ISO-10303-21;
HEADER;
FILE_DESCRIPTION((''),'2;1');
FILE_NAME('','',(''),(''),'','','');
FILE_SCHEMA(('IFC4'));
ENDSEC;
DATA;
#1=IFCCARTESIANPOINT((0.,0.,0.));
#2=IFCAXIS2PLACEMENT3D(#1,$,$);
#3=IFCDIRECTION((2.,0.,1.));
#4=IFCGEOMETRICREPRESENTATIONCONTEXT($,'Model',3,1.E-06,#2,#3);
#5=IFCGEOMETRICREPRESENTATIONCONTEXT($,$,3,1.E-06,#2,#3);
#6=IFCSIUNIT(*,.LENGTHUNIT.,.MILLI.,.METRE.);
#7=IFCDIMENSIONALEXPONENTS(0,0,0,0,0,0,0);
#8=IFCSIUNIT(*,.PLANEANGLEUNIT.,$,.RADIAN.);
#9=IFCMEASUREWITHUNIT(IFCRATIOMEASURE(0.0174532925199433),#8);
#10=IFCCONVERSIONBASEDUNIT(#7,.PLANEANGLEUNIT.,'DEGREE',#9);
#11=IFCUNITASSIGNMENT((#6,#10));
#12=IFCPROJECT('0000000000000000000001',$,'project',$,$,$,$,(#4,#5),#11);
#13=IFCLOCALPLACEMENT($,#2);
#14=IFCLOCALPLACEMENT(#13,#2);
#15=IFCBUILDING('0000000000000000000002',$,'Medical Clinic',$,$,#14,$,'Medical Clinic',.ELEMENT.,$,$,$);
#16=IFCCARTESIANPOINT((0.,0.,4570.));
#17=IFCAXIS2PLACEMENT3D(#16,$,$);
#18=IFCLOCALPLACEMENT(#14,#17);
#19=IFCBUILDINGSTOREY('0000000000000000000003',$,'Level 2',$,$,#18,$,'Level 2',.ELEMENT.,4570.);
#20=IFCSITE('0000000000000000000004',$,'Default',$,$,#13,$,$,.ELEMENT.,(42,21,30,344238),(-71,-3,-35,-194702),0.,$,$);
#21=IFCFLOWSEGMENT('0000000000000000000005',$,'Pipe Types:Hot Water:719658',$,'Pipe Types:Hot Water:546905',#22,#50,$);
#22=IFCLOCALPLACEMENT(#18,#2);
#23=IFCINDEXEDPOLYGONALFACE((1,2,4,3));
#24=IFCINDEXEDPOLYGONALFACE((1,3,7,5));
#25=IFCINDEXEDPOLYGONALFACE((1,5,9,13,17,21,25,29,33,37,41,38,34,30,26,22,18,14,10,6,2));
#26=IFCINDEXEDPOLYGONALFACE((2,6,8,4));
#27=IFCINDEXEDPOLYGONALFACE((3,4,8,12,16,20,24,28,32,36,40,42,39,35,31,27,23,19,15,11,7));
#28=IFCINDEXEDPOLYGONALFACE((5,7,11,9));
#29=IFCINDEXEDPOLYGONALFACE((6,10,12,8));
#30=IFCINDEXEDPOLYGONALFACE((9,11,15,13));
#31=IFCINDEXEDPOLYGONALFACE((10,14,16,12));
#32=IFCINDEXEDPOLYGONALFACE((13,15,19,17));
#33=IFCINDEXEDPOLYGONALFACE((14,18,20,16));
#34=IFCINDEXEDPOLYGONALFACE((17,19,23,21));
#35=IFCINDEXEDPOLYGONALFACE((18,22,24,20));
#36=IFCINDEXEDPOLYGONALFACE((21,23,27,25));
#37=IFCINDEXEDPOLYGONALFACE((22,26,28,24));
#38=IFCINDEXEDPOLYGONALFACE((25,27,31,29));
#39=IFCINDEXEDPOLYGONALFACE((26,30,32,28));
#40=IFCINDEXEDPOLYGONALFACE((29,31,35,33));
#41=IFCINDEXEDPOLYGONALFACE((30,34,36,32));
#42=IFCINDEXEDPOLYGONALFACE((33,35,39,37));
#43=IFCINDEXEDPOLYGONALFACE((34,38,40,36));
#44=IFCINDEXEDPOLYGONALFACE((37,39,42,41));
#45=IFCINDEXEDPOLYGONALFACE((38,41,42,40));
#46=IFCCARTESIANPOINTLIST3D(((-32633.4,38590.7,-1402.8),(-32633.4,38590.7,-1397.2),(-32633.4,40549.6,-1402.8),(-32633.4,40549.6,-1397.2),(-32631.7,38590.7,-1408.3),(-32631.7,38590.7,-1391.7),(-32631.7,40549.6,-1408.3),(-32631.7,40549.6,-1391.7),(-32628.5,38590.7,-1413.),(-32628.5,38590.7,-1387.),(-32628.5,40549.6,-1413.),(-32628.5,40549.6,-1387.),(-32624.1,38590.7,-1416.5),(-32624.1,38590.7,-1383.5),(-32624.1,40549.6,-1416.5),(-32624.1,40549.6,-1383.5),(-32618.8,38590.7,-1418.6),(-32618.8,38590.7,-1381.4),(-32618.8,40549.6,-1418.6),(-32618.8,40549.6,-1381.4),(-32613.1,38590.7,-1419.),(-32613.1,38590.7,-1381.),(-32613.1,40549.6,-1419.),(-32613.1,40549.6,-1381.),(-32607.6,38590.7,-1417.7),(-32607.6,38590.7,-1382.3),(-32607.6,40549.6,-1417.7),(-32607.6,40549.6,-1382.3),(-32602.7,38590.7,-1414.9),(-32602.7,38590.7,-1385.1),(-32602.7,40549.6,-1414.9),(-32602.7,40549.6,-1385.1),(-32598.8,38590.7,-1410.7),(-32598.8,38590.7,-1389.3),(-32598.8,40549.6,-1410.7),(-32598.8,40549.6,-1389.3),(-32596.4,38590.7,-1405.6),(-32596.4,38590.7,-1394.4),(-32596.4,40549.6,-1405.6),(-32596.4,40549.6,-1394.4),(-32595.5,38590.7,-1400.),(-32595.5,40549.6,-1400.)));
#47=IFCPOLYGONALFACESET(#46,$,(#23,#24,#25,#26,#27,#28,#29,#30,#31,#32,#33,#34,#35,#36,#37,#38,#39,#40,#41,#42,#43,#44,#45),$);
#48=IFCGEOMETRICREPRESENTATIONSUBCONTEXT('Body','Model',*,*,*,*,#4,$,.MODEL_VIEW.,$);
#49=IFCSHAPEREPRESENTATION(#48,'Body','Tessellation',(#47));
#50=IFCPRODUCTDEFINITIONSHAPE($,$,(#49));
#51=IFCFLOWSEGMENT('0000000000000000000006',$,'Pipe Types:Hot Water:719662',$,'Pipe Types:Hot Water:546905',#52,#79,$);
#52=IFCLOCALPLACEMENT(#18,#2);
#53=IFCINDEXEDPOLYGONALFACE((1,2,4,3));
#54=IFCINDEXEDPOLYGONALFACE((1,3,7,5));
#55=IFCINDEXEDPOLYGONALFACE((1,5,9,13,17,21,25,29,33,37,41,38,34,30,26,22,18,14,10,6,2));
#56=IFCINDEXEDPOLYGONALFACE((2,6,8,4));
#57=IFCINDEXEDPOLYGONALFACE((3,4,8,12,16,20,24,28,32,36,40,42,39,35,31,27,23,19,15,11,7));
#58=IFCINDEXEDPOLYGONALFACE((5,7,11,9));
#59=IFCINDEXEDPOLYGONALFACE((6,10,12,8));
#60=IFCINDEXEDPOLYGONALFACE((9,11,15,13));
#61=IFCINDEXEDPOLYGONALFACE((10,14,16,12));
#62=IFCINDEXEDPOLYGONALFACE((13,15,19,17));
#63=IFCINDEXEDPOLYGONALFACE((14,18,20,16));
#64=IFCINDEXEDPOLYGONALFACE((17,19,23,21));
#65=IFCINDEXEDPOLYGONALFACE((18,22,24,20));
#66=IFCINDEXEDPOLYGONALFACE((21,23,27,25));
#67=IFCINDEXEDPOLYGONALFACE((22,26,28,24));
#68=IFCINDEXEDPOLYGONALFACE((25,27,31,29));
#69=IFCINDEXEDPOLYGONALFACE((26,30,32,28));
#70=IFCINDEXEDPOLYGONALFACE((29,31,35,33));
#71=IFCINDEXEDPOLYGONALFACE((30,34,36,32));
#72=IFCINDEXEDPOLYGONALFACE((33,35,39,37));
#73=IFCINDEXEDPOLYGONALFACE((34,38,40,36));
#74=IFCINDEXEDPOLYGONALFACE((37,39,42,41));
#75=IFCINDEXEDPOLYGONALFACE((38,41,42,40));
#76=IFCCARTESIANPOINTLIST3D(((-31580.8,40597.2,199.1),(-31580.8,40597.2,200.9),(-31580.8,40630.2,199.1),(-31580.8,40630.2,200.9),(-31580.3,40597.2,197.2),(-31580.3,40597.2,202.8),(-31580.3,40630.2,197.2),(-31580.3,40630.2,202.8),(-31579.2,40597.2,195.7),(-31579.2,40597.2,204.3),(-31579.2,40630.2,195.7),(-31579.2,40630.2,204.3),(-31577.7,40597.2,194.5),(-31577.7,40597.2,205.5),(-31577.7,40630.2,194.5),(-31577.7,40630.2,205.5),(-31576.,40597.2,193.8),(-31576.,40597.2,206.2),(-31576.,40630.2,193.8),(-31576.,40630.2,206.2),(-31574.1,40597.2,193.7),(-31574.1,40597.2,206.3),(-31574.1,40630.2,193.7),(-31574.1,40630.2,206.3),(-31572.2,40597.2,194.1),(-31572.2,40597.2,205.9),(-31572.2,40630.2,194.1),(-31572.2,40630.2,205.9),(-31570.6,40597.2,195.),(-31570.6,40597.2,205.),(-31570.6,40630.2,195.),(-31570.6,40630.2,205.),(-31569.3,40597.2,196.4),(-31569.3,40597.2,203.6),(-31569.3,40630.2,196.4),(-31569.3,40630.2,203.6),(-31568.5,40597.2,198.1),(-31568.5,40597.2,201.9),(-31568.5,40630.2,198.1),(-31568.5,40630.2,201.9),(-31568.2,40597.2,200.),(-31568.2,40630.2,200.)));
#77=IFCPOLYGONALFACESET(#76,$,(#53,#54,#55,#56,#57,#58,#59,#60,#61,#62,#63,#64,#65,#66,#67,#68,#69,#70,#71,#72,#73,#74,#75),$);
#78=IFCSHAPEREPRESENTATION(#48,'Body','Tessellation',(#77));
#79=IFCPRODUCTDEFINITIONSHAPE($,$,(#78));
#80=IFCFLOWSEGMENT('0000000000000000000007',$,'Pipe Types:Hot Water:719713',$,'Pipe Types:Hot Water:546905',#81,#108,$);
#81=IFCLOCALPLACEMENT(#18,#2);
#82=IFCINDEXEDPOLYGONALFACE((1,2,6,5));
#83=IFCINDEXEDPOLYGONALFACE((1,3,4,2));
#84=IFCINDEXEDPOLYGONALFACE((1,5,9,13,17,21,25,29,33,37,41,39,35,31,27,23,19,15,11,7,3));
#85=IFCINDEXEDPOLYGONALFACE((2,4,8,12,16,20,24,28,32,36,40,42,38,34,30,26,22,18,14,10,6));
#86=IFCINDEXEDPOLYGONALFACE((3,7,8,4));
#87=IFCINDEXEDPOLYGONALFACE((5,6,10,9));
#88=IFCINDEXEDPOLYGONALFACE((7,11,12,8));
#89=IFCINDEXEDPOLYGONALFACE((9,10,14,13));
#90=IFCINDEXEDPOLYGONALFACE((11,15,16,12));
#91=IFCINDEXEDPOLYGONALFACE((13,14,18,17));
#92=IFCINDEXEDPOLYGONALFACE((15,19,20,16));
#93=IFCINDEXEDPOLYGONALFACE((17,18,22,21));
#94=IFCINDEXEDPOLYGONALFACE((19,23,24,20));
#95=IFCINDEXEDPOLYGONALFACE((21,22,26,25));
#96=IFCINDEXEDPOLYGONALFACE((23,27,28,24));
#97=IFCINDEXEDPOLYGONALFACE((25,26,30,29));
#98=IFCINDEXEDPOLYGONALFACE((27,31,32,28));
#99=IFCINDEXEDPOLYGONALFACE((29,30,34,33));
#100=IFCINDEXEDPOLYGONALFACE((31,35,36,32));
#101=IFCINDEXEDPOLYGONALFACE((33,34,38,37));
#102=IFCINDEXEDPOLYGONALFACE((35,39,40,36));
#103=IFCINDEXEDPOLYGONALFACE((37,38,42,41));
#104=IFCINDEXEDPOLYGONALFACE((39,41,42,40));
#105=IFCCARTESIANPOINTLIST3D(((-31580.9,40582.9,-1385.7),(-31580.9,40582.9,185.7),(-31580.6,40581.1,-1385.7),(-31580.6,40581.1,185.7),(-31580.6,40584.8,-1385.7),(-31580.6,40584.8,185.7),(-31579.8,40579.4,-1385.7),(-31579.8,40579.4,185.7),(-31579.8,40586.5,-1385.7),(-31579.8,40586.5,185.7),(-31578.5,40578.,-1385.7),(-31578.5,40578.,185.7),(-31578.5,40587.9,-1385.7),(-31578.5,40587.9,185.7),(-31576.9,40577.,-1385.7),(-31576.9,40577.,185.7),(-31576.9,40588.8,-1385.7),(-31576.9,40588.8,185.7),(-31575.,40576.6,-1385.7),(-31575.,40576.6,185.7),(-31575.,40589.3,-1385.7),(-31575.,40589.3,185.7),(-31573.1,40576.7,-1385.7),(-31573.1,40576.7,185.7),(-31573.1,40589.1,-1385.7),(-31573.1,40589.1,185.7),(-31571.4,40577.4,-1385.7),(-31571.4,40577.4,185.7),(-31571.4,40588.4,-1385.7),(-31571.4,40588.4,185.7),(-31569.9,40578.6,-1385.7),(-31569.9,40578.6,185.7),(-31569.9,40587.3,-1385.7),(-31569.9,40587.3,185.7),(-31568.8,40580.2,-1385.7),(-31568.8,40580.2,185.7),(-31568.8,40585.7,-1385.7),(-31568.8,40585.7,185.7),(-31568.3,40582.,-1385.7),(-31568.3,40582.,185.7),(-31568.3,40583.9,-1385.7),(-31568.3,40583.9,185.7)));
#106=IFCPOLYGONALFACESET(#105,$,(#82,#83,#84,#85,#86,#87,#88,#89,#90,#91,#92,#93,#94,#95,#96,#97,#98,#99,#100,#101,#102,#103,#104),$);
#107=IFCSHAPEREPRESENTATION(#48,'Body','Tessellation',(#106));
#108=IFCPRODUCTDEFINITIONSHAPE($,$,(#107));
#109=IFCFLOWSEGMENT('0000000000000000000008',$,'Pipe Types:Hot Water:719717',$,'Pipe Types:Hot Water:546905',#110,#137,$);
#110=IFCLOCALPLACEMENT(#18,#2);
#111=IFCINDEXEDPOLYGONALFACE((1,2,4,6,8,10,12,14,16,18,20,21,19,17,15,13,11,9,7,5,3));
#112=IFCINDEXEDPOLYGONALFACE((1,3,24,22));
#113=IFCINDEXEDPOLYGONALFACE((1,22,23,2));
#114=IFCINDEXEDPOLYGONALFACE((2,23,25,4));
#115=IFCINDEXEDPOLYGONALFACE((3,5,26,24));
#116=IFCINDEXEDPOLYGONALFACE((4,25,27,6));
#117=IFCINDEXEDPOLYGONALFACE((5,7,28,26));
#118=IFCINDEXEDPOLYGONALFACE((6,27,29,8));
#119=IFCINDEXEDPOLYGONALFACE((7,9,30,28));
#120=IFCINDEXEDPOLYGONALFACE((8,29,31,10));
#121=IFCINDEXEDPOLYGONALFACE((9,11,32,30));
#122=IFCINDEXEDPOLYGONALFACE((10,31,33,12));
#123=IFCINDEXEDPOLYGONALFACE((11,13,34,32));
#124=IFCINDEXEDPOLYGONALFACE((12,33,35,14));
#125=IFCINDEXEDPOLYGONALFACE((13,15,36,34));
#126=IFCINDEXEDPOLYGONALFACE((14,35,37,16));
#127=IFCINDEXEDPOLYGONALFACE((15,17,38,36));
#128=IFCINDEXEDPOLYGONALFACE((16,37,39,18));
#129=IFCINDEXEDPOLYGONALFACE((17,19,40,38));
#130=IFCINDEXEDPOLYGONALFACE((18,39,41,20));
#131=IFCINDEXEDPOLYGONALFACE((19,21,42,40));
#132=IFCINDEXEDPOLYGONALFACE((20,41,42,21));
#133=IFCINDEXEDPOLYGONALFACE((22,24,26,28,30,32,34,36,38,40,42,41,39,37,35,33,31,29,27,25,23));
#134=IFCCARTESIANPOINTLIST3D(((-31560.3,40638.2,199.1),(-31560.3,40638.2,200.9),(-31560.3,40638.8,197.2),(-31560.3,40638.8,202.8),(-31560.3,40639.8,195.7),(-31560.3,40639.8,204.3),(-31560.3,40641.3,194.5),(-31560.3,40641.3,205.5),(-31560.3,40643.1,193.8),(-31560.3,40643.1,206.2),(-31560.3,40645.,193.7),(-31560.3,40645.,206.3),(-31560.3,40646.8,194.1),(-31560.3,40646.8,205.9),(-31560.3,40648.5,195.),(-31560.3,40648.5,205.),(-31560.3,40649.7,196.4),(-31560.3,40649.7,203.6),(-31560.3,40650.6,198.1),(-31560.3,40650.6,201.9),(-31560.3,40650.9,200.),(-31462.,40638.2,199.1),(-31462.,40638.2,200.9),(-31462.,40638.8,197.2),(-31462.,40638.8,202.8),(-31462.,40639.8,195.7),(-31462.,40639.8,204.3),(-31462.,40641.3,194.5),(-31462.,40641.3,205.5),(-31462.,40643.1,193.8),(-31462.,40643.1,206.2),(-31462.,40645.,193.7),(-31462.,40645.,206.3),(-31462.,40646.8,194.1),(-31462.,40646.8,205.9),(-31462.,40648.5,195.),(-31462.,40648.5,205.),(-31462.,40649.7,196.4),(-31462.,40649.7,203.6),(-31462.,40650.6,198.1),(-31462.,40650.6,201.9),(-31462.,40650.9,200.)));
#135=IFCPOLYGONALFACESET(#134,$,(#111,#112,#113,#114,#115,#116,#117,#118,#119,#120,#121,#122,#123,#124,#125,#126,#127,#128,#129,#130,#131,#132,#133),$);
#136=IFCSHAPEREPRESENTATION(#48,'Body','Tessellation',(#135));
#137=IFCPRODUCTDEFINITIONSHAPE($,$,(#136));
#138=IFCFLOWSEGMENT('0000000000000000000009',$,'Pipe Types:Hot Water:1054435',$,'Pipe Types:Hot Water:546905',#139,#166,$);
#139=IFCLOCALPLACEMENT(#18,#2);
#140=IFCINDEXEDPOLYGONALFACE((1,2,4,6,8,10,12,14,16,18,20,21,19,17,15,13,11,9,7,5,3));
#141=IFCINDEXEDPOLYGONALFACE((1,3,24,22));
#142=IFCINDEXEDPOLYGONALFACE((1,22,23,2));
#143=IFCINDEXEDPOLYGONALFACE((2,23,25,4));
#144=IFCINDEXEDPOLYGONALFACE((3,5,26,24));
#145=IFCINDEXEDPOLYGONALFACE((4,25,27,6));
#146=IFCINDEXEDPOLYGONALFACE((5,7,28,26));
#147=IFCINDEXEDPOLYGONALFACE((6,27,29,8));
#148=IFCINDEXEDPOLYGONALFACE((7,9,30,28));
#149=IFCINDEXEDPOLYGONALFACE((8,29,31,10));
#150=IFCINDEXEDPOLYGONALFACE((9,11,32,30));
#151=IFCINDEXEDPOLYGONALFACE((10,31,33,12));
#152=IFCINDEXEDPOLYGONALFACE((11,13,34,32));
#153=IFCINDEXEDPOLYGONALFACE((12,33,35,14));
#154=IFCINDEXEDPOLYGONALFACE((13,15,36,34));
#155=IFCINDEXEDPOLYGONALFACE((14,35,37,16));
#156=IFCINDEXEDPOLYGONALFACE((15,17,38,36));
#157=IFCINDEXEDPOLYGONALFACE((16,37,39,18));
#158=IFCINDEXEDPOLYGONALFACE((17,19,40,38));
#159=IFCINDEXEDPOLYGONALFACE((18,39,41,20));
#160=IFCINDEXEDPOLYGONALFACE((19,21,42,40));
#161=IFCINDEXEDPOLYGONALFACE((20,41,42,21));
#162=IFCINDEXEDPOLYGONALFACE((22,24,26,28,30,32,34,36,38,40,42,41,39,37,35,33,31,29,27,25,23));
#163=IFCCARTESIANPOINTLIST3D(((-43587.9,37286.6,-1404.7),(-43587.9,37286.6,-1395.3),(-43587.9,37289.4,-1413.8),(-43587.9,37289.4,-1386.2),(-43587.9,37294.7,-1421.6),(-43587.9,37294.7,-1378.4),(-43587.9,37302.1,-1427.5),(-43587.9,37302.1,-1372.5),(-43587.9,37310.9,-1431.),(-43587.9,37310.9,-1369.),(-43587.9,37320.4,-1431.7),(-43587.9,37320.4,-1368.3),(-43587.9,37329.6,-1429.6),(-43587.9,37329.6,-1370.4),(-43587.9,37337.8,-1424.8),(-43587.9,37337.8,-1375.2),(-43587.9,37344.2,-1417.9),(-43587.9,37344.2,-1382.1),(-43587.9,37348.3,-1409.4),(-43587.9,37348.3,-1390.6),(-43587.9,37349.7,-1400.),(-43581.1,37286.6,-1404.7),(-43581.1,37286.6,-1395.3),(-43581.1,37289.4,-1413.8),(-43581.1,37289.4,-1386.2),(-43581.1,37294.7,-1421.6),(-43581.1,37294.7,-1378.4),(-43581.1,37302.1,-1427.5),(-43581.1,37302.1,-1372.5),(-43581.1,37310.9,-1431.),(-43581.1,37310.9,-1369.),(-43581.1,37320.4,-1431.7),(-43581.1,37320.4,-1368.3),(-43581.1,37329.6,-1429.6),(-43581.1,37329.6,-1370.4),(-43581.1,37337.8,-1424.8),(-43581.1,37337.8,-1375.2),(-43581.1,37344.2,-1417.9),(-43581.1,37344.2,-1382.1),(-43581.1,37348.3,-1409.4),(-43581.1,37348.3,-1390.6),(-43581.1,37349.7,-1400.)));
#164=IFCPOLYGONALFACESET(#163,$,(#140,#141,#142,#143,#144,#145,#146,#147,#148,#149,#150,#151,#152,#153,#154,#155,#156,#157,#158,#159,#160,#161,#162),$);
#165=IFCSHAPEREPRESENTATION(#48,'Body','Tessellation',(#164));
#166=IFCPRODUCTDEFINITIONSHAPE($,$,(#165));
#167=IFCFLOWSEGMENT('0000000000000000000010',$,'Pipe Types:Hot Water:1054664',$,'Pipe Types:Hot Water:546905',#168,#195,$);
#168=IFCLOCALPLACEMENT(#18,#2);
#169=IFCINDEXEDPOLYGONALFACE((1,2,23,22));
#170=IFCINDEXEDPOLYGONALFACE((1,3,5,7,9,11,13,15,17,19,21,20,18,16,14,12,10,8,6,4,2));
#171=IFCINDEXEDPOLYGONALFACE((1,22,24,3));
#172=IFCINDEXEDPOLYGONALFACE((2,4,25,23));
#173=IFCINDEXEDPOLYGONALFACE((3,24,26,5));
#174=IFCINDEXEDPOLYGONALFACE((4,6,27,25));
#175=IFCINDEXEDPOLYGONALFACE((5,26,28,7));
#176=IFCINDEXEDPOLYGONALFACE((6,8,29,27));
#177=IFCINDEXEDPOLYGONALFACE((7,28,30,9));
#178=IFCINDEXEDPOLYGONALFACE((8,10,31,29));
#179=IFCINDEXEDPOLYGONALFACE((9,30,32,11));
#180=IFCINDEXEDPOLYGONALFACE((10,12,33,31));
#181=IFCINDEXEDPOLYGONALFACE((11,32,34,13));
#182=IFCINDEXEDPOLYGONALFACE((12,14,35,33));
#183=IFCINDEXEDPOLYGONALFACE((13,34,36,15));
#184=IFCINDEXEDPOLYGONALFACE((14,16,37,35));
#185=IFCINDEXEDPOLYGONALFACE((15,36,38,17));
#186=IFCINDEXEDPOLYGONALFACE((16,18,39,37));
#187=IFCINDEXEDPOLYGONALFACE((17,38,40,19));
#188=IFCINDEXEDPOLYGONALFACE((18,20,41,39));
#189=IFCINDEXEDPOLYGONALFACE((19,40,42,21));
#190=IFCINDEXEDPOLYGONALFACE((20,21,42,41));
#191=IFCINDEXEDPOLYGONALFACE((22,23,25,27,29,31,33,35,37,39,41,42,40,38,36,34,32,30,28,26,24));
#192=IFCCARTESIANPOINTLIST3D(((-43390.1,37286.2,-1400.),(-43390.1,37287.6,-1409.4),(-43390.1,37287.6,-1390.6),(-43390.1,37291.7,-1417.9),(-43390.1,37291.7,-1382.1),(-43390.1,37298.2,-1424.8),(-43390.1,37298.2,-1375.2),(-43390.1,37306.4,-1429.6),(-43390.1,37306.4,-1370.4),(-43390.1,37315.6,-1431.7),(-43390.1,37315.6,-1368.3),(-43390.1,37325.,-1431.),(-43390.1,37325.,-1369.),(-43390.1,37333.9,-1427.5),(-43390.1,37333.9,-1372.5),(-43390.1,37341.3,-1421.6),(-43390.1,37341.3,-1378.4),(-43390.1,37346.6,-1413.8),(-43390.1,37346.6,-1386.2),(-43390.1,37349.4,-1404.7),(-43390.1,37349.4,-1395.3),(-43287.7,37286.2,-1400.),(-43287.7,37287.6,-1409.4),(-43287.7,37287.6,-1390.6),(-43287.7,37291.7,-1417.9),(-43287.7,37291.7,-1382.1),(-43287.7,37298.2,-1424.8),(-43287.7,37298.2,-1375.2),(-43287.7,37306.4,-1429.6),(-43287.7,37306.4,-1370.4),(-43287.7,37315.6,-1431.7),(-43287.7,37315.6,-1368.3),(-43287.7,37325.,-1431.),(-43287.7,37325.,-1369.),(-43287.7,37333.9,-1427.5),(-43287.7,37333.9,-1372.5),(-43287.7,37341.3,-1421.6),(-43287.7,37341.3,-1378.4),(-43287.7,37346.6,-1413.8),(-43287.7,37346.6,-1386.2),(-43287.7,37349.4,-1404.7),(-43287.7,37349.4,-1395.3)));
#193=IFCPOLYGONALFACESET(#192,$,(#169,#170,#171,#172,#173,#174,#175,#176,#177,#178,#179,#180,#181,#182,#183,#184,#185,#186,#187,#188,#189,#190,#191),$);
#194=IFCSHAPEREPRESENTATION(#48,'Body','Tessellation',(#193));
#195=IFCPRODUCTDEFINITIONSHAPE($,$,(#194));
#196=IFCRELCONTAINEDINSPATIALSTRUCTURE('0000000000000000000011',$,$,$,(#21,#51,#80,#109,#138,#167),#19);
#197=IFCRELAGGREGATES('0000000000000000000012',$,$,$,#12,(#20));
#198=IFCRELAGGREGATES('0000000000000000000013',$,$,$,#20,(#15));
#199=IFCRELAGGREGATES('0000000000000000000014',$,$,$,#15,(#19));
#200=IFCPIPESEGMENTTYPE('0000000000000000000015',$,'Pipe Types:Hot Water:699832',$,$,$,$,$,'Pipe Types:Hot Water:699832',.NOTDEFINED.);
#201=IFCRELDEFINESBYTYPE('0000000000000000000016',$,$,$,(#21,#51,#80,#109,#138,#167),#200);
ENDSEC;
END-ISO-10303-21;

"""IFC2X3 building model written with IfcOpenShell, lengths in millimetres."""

from ifc_helpers import new_model, entity, si_unit, converted_unit, direction, frame, frame_2d, origin, origin_2d_with_axis, place, context, subcontext, project, spatial, circle, extrude, type_object, element, save


model = new_model("IFC2X3")

# Units and contexts
model_context = context("Model", 3, precision=1e-06, world=origin(), true_north=direction((2.0, 0.0, 1.0)))
context_of_model = context(None, 3, precision=1e-06, world=origin(), true_north=direction((2.0, 0.0, 1.0)))
body_context = subcontext(model_context, "Body", "Model", "MODEL_VIEW")
ifc_project = project(units=[si_unit("LENGTHUNIT", "METRE", prefix="MILLI"), converted_unit("PLANEANGLEUNIT", "DEGREE", entity("IfcRatioMeasure", 0.0174532925199433), si_unit("PLANEANGLEUNIT", "RADIAN"), dimensions=[0, 0, 0, 0, 0, 0, 0])], contexts=[model_context, context_of_model])

# Site, building, storey
site_placement = place(None, origin())
site = spatial("IfcSite", under=ifc_project, at=site_placement, Name="Default", CompositionType="ELEMENT", RefLatitude=(42, 21, 30, 344238), RefLongitude=(-71, -3, -35, -194702), RefElevation=0.0)
building_placement = place(site_placement, origin())
building = spatial("IfcBuilding", under=site, at=building_placement, Name="Medical Clinic", LongName="Medical Clinic", CompositionType="ELEMENT")
storey_placement = place(building_placement, frame((0.0, 0.0, 4570.0)))
storey = spatial("IfcBuildingStorey", under=building, at=storey_placement, Name="Level 2", LongName="Level 2", CompositionType="ELEMENT", Elevation=4570.0)

# Flow segments
pipe_segment_type_1 = type_object("IfcPipeSegmentType", Name="Pipe Types:Hot Water:699832", ElementType="Pipe Types:Hot Water:699832", PredefinedType="NOTDEFINED")
flow_segment_1_placement = place(storey_placement, origin())
element("IfcFlowSegment", 1, at=flow_segment_1_placement, inside=storey, type_object=pipe_segment_type_1, Name="Pipe Types:Hot Water:719658", ObjectType="Pipe Types:Hot Water:546905", context=body_context, shape_type="SweptSolid", body=[
    extrude(circle(Radius=19.1, at=origin_2d_with_axis()), frame((-32614.6, 38590.7, -1400.0), z_axis=(0.0, 1.0, 0.0), x_axis=(1.0, 0.0, 0.0)), (0.0, 0.0, 1.0), 1958.9),
])
flow_segment_2_placement = place(storey_placement, origin())
element("IfcFlowSegment", 2, at=flow_segment_2_placement, inside=storey, type_object=pipe_segment_type_1, Name="Pipe Types:Hot Water:719662", ObjectType="Pipe Types:Hot Water:546905", context=body_context, shape_type="SweptSolid", body=[
    extrude(circle(Radius=6.3, at=frame_2d((0.0, 0.0), x_axis=(1.0, 0.0))), frame((-31574.6, 40597.2, 200.0), z_axis=(0.0, 1.0, 0.0), x_axis=(1.0, 0.0, 0.0)), (0.0, 0.0, 1.0), 33.0),
])
flow_segment_3_placement = place(storey_placement, origin())
element("IfcFlowSegment", 3, at=flow_segment_3_placement, inside=storey, type_object=pipe_segment_type_1, Name="Pipe Types:Hot Water:719713", ObjectType="Pipe Types:Hot Water:546905", context=body_context, shape_type="SweptSolid", body=[
    extrude(circle(Radius=6.3, at=origin_2d_with_axis()), frame((-31574.6, 40582.9, -1385.7), z_axis=(0.0, 0.0, 1.0), x_axis=(-1.0, 0.0, 0.0)), (0.0, 0.0, 1.0), 1571.4),
])
flow_segment_4_placement = place(storey_placement, origin())
element("IfcFlowSegment", 4, at=flow_segment_4_placement, inside=storey, type_object=pipe_segment_type_1, Name="Pipe Types:Hot Water:719717", ObjectType="Pipe Types:Hot Water:546905", context=body_context, shape_type="SweptSolid", body=[
    extrude(circle(Radius=6.3, at=origin_2d_with_axis()), frame((-31560.3, 40644.5, 200.0), z_axis=(1.0, 0.0, 0.0), x_axis=(0.0, 1.0, 0.0)), (0.0, 0.0, 1.0), 98.3),
])
flow_segment_5_placement = place(storey_placement, origin())
element("IfcFlowSegment", 5, at=flow_segment_5_placement, inside=storey, type_object=pipe_segment_type_1, Name="Pipe Types:Hot Water:1054435", ObjectType="Pipe Types:Hot Water:546905", context=body_context, shape_type="SweptSolid", body=[
    extrude(circle(Radius=31.8, at=origin_2d_with_axis()), frame((-43587.9, 37318.0, -1400.0), z_axis=(1.0, 0.0, 0.0), x_axis=(0.0, 1.0, 0.0)), (0.0, 0.0, 1.0), 6.8),
])
flow_segment_6_placement = place(storey_placement, origin())
element("IfcFlowSegment", 6, at=flow_segment_6_placement, inside=storey, type_object=pipe_segment_type_1, Name="Pipe Types:Hot Water:1054664", ObjectType="Pipe Types:Hot Water:546905", context=body_context, shape_type="SweptSolid", body=[
    extrude(circle(Radius=31.8, at=origin_2d_with_axis()), frame((-43390.1, 37318.0, -1400.0), z_axis=(1.0, 0.0, 0.0), x_axis=(0.0, -1.0, 0.0)), (0.0, 0.0, 1.0), 102.4),
])

save(model, "model.ifc")
